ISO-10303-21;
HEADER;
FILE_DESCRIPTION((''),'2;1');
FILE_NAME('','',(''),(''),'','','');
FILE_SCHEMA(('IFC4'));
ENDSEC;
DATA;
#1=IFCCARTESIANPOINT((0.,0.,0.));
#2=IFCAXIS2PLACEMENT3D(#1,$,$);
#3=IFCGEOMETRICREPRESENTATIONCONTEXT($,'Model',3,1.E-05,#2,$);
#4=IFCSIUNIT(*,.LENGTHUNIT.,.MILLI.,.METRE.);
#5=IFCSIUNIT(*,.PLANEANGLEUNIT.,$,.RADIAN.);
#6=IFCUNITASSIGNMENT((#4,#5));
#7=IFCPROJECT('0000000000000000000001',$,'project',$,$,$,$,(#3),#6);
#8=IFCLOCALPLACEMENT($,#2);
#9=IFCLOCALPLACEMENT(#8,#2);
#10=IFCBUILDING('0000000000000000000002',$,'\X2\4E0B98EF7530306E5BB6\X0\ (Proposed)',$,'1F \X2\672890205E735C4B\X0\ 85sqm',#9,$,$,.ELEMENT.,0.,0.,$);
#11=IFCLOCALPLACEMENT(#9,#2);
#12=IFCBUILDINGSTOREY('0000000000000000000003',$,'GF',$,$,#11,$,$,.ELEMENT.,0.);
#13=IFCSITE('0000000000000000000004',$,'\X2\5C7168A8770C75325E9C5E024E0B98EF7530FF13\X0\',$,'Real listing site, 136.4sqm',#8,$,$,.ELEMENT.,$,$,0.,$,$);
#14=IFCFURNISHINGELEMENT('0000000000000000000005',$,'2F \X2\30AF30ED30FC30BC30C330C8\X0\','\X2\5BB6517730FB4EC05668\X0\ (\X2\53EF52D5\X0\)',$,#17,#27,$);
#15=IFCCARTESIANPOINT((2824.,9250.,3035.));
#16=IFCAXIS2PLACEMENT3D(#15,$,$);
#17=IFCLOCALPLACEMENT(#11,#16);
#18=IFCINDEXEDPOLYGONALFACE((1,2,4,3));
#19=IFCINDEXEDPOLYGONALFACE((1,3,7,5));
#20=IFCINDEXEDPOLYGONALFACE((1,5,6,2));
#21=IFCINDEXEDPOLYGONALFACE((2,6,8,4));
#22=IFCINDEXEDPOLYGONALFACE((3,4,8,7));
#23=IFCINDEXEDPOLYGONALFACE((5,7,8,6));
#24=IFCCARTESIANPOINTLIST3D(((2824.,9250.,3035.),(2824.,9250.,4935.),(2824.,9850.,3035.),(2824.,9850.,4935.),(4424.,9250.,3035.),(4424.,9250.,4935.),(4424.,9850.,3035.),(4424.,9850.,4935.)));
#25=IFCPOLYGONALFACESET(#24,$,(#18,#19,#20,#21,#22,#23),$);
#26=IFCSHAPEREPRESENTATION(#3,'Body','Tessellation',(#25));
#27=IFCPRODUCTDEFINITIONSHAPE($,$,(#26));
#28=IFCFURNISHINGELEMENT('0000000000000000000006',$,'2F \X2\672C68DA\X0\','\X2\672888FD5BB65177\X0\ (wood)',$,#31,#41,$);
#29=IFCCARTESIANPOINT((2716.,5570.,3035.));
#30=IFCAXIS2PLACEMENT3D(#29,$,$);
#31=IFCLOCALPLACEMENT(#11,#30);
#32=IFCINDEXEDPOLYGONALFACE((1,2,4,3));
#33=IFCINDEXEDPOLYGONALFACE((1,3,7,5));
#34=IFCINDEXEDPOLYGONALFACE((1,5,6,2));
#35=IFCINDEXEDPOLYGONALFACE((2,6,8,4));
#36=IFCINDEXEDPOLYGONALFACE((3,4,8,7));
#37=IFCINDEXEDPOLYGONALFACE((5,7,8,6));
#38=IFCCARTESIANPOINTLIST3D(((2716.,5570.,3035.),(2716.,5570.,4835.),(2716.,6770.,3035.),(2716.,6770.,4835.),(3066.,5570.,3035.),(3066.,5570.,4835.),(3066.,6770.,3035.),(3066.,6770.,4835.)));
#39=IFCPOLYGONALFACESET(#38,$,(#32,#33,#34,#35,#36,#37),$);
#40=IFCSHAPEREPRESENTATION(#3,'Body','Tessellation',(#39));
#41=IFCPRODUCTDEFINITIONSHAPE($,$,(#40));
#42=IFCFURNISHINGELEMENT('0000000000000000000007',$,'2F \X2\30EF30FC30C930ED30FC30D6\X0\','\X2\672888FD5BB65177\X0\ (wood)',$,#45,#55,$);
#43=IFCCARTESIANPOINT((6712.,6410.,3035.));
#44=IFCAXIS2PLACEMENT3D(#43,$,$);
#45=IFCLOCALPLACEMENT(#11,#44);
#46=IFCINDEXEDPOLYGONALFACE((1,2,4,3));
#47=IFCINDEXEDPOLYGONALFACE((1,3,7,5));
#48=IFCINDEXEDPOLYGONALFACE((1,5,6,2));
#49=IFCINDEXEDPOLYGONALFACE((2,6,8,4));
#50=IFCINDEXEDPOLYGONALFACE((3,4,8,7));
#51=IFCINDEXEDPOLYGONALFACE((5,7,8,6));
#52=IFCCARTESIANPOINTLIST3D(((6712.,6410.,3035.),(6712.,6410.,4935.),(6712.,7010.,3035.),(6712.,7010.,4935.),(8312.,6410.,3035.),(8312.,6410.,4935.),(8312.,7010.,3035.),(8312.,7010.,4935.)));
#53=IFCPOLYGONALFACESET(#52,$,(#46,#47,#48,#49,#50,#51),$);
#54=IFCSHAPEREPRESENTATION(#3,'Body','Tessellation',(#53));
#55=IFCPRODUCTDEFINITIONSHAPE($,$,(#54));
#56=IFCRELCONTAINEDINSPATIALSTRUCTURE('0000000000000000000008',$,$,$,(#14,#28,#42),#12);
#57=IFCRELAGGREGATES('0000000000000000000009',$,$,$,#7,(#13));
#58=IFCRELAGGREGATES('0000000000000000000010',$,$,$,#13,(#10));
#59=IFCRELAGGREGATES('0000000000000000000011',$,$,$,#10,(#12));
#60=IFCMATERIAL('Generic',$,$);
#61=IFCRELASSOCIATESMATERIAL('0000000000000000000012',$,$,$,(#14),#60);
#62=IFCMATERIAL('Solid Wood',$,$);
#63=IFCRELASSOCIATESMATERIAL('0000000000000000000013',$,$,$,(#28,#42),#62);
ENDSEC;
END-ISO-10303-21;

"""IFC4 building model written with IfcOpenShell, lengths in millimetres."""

from ifc_helpers import new_model, si_unit, frame, frame_2d, origin, place, context, project, spatial, rectangle, extrude, material, element, save


model = new_model("IFC4")

# Units and contexts
model_context = context("Model", 3, precision=1e-05, world=origin())
ifc_project = project(units=[si_unit("LENGTHUNIT", "METRE", prefix="MILLI"), si_unit("PLANEANGLEUNIT", "RADIAN")], contexts=[model_context])

# Site, building, storey
site_placement = place(None, origin())
site = spatial("IfcSite", under=ifc_project, at=site_placement, Name="山梨県甲府市下飯田３", ObjectType="Real listing site, 136.4sqm", CompositionType="ELEMENT", RefElevation=0.0)
building_placement = place(site_placement, origin())
building = spatial("IfcBuilding", under=site, at=building_placement, Name="下飯田の家 (Proposed)", ObjectType="1F 木造平屋 85sqm", CompositionType="ELEMENT", ElevationOfRefHeight=0.0, ElevationOfTerrain=0.0)
storey_placement = place(building_placement, origin())
storey = spatial("IfcBuildingStorey", under=building, at=storey_placement, Name="GF", CompositionType="ELEMENT", Elevation=0.0)

# Shared definitions
ifc_material_1 = material(Name="Solid Wood")

# Shared definitions
ifc_material_2 = material(Name="Generic")

# Furnishing elements
furnishing_1_placement = place(storey_placement, frame((2824.0, 9250.0, 3035.0)))
element("IfcFurnishingElement", 1, at=furnishing_1_placement, inside=storey, material=ifc_material_2, Name="2F クローゼット", Description="家具・什器 (可動)", context=model_context, shape_type="SweptSolid", body=[
    extrude(rectangle(XDim=1600.0, YDim=600.0, at=frame_2d((800.0, 300.0))), frame((2824.0, 9250.0, 3035.0)), (0.0, 0.0, 1.0), 1900.0),
])
furnishing_2_placement = place(storey_placement, frame((2716.0, 5570.0, 3035.0)))
element("IfcFurnishingElement", 2, at=furnishing_2_placement, inside=storey, material=ifc_material_1, Name="2F 本棚", Description="木製家具 (wood)", context=model_context, shape_type="SweptSolid", body=[
    extrude(rectangle(XDim=350.0, YDim=1200.0, at=frame_2d((175.0, 600.0))), frame((2716.0, 5570.0, 3035.0)), (0.0, 0.0, 1.0), 1800.0),
])
furnishing_3_placement = place(storey_placement, frame((6712.0, 6410.0, 3035.0)))
element("IfcFurnishingElement", 3, at=furnishing_3_placement, inside=storey, material=ifc_material_1, Name="2F ワードローブ", Description="木製家具 (wood)", context=model_context, shape_type="SweptSolid", body=[
    extrude(rectangle(XDim=1600.0, YDim=600.0, at=frame_2d((800.0, 300.0))), frame((6712.0, 6410.0, 3035.0)), (0.0, 0.0, 1.0), 1900.0),
])

save(model, "model.ifc")
